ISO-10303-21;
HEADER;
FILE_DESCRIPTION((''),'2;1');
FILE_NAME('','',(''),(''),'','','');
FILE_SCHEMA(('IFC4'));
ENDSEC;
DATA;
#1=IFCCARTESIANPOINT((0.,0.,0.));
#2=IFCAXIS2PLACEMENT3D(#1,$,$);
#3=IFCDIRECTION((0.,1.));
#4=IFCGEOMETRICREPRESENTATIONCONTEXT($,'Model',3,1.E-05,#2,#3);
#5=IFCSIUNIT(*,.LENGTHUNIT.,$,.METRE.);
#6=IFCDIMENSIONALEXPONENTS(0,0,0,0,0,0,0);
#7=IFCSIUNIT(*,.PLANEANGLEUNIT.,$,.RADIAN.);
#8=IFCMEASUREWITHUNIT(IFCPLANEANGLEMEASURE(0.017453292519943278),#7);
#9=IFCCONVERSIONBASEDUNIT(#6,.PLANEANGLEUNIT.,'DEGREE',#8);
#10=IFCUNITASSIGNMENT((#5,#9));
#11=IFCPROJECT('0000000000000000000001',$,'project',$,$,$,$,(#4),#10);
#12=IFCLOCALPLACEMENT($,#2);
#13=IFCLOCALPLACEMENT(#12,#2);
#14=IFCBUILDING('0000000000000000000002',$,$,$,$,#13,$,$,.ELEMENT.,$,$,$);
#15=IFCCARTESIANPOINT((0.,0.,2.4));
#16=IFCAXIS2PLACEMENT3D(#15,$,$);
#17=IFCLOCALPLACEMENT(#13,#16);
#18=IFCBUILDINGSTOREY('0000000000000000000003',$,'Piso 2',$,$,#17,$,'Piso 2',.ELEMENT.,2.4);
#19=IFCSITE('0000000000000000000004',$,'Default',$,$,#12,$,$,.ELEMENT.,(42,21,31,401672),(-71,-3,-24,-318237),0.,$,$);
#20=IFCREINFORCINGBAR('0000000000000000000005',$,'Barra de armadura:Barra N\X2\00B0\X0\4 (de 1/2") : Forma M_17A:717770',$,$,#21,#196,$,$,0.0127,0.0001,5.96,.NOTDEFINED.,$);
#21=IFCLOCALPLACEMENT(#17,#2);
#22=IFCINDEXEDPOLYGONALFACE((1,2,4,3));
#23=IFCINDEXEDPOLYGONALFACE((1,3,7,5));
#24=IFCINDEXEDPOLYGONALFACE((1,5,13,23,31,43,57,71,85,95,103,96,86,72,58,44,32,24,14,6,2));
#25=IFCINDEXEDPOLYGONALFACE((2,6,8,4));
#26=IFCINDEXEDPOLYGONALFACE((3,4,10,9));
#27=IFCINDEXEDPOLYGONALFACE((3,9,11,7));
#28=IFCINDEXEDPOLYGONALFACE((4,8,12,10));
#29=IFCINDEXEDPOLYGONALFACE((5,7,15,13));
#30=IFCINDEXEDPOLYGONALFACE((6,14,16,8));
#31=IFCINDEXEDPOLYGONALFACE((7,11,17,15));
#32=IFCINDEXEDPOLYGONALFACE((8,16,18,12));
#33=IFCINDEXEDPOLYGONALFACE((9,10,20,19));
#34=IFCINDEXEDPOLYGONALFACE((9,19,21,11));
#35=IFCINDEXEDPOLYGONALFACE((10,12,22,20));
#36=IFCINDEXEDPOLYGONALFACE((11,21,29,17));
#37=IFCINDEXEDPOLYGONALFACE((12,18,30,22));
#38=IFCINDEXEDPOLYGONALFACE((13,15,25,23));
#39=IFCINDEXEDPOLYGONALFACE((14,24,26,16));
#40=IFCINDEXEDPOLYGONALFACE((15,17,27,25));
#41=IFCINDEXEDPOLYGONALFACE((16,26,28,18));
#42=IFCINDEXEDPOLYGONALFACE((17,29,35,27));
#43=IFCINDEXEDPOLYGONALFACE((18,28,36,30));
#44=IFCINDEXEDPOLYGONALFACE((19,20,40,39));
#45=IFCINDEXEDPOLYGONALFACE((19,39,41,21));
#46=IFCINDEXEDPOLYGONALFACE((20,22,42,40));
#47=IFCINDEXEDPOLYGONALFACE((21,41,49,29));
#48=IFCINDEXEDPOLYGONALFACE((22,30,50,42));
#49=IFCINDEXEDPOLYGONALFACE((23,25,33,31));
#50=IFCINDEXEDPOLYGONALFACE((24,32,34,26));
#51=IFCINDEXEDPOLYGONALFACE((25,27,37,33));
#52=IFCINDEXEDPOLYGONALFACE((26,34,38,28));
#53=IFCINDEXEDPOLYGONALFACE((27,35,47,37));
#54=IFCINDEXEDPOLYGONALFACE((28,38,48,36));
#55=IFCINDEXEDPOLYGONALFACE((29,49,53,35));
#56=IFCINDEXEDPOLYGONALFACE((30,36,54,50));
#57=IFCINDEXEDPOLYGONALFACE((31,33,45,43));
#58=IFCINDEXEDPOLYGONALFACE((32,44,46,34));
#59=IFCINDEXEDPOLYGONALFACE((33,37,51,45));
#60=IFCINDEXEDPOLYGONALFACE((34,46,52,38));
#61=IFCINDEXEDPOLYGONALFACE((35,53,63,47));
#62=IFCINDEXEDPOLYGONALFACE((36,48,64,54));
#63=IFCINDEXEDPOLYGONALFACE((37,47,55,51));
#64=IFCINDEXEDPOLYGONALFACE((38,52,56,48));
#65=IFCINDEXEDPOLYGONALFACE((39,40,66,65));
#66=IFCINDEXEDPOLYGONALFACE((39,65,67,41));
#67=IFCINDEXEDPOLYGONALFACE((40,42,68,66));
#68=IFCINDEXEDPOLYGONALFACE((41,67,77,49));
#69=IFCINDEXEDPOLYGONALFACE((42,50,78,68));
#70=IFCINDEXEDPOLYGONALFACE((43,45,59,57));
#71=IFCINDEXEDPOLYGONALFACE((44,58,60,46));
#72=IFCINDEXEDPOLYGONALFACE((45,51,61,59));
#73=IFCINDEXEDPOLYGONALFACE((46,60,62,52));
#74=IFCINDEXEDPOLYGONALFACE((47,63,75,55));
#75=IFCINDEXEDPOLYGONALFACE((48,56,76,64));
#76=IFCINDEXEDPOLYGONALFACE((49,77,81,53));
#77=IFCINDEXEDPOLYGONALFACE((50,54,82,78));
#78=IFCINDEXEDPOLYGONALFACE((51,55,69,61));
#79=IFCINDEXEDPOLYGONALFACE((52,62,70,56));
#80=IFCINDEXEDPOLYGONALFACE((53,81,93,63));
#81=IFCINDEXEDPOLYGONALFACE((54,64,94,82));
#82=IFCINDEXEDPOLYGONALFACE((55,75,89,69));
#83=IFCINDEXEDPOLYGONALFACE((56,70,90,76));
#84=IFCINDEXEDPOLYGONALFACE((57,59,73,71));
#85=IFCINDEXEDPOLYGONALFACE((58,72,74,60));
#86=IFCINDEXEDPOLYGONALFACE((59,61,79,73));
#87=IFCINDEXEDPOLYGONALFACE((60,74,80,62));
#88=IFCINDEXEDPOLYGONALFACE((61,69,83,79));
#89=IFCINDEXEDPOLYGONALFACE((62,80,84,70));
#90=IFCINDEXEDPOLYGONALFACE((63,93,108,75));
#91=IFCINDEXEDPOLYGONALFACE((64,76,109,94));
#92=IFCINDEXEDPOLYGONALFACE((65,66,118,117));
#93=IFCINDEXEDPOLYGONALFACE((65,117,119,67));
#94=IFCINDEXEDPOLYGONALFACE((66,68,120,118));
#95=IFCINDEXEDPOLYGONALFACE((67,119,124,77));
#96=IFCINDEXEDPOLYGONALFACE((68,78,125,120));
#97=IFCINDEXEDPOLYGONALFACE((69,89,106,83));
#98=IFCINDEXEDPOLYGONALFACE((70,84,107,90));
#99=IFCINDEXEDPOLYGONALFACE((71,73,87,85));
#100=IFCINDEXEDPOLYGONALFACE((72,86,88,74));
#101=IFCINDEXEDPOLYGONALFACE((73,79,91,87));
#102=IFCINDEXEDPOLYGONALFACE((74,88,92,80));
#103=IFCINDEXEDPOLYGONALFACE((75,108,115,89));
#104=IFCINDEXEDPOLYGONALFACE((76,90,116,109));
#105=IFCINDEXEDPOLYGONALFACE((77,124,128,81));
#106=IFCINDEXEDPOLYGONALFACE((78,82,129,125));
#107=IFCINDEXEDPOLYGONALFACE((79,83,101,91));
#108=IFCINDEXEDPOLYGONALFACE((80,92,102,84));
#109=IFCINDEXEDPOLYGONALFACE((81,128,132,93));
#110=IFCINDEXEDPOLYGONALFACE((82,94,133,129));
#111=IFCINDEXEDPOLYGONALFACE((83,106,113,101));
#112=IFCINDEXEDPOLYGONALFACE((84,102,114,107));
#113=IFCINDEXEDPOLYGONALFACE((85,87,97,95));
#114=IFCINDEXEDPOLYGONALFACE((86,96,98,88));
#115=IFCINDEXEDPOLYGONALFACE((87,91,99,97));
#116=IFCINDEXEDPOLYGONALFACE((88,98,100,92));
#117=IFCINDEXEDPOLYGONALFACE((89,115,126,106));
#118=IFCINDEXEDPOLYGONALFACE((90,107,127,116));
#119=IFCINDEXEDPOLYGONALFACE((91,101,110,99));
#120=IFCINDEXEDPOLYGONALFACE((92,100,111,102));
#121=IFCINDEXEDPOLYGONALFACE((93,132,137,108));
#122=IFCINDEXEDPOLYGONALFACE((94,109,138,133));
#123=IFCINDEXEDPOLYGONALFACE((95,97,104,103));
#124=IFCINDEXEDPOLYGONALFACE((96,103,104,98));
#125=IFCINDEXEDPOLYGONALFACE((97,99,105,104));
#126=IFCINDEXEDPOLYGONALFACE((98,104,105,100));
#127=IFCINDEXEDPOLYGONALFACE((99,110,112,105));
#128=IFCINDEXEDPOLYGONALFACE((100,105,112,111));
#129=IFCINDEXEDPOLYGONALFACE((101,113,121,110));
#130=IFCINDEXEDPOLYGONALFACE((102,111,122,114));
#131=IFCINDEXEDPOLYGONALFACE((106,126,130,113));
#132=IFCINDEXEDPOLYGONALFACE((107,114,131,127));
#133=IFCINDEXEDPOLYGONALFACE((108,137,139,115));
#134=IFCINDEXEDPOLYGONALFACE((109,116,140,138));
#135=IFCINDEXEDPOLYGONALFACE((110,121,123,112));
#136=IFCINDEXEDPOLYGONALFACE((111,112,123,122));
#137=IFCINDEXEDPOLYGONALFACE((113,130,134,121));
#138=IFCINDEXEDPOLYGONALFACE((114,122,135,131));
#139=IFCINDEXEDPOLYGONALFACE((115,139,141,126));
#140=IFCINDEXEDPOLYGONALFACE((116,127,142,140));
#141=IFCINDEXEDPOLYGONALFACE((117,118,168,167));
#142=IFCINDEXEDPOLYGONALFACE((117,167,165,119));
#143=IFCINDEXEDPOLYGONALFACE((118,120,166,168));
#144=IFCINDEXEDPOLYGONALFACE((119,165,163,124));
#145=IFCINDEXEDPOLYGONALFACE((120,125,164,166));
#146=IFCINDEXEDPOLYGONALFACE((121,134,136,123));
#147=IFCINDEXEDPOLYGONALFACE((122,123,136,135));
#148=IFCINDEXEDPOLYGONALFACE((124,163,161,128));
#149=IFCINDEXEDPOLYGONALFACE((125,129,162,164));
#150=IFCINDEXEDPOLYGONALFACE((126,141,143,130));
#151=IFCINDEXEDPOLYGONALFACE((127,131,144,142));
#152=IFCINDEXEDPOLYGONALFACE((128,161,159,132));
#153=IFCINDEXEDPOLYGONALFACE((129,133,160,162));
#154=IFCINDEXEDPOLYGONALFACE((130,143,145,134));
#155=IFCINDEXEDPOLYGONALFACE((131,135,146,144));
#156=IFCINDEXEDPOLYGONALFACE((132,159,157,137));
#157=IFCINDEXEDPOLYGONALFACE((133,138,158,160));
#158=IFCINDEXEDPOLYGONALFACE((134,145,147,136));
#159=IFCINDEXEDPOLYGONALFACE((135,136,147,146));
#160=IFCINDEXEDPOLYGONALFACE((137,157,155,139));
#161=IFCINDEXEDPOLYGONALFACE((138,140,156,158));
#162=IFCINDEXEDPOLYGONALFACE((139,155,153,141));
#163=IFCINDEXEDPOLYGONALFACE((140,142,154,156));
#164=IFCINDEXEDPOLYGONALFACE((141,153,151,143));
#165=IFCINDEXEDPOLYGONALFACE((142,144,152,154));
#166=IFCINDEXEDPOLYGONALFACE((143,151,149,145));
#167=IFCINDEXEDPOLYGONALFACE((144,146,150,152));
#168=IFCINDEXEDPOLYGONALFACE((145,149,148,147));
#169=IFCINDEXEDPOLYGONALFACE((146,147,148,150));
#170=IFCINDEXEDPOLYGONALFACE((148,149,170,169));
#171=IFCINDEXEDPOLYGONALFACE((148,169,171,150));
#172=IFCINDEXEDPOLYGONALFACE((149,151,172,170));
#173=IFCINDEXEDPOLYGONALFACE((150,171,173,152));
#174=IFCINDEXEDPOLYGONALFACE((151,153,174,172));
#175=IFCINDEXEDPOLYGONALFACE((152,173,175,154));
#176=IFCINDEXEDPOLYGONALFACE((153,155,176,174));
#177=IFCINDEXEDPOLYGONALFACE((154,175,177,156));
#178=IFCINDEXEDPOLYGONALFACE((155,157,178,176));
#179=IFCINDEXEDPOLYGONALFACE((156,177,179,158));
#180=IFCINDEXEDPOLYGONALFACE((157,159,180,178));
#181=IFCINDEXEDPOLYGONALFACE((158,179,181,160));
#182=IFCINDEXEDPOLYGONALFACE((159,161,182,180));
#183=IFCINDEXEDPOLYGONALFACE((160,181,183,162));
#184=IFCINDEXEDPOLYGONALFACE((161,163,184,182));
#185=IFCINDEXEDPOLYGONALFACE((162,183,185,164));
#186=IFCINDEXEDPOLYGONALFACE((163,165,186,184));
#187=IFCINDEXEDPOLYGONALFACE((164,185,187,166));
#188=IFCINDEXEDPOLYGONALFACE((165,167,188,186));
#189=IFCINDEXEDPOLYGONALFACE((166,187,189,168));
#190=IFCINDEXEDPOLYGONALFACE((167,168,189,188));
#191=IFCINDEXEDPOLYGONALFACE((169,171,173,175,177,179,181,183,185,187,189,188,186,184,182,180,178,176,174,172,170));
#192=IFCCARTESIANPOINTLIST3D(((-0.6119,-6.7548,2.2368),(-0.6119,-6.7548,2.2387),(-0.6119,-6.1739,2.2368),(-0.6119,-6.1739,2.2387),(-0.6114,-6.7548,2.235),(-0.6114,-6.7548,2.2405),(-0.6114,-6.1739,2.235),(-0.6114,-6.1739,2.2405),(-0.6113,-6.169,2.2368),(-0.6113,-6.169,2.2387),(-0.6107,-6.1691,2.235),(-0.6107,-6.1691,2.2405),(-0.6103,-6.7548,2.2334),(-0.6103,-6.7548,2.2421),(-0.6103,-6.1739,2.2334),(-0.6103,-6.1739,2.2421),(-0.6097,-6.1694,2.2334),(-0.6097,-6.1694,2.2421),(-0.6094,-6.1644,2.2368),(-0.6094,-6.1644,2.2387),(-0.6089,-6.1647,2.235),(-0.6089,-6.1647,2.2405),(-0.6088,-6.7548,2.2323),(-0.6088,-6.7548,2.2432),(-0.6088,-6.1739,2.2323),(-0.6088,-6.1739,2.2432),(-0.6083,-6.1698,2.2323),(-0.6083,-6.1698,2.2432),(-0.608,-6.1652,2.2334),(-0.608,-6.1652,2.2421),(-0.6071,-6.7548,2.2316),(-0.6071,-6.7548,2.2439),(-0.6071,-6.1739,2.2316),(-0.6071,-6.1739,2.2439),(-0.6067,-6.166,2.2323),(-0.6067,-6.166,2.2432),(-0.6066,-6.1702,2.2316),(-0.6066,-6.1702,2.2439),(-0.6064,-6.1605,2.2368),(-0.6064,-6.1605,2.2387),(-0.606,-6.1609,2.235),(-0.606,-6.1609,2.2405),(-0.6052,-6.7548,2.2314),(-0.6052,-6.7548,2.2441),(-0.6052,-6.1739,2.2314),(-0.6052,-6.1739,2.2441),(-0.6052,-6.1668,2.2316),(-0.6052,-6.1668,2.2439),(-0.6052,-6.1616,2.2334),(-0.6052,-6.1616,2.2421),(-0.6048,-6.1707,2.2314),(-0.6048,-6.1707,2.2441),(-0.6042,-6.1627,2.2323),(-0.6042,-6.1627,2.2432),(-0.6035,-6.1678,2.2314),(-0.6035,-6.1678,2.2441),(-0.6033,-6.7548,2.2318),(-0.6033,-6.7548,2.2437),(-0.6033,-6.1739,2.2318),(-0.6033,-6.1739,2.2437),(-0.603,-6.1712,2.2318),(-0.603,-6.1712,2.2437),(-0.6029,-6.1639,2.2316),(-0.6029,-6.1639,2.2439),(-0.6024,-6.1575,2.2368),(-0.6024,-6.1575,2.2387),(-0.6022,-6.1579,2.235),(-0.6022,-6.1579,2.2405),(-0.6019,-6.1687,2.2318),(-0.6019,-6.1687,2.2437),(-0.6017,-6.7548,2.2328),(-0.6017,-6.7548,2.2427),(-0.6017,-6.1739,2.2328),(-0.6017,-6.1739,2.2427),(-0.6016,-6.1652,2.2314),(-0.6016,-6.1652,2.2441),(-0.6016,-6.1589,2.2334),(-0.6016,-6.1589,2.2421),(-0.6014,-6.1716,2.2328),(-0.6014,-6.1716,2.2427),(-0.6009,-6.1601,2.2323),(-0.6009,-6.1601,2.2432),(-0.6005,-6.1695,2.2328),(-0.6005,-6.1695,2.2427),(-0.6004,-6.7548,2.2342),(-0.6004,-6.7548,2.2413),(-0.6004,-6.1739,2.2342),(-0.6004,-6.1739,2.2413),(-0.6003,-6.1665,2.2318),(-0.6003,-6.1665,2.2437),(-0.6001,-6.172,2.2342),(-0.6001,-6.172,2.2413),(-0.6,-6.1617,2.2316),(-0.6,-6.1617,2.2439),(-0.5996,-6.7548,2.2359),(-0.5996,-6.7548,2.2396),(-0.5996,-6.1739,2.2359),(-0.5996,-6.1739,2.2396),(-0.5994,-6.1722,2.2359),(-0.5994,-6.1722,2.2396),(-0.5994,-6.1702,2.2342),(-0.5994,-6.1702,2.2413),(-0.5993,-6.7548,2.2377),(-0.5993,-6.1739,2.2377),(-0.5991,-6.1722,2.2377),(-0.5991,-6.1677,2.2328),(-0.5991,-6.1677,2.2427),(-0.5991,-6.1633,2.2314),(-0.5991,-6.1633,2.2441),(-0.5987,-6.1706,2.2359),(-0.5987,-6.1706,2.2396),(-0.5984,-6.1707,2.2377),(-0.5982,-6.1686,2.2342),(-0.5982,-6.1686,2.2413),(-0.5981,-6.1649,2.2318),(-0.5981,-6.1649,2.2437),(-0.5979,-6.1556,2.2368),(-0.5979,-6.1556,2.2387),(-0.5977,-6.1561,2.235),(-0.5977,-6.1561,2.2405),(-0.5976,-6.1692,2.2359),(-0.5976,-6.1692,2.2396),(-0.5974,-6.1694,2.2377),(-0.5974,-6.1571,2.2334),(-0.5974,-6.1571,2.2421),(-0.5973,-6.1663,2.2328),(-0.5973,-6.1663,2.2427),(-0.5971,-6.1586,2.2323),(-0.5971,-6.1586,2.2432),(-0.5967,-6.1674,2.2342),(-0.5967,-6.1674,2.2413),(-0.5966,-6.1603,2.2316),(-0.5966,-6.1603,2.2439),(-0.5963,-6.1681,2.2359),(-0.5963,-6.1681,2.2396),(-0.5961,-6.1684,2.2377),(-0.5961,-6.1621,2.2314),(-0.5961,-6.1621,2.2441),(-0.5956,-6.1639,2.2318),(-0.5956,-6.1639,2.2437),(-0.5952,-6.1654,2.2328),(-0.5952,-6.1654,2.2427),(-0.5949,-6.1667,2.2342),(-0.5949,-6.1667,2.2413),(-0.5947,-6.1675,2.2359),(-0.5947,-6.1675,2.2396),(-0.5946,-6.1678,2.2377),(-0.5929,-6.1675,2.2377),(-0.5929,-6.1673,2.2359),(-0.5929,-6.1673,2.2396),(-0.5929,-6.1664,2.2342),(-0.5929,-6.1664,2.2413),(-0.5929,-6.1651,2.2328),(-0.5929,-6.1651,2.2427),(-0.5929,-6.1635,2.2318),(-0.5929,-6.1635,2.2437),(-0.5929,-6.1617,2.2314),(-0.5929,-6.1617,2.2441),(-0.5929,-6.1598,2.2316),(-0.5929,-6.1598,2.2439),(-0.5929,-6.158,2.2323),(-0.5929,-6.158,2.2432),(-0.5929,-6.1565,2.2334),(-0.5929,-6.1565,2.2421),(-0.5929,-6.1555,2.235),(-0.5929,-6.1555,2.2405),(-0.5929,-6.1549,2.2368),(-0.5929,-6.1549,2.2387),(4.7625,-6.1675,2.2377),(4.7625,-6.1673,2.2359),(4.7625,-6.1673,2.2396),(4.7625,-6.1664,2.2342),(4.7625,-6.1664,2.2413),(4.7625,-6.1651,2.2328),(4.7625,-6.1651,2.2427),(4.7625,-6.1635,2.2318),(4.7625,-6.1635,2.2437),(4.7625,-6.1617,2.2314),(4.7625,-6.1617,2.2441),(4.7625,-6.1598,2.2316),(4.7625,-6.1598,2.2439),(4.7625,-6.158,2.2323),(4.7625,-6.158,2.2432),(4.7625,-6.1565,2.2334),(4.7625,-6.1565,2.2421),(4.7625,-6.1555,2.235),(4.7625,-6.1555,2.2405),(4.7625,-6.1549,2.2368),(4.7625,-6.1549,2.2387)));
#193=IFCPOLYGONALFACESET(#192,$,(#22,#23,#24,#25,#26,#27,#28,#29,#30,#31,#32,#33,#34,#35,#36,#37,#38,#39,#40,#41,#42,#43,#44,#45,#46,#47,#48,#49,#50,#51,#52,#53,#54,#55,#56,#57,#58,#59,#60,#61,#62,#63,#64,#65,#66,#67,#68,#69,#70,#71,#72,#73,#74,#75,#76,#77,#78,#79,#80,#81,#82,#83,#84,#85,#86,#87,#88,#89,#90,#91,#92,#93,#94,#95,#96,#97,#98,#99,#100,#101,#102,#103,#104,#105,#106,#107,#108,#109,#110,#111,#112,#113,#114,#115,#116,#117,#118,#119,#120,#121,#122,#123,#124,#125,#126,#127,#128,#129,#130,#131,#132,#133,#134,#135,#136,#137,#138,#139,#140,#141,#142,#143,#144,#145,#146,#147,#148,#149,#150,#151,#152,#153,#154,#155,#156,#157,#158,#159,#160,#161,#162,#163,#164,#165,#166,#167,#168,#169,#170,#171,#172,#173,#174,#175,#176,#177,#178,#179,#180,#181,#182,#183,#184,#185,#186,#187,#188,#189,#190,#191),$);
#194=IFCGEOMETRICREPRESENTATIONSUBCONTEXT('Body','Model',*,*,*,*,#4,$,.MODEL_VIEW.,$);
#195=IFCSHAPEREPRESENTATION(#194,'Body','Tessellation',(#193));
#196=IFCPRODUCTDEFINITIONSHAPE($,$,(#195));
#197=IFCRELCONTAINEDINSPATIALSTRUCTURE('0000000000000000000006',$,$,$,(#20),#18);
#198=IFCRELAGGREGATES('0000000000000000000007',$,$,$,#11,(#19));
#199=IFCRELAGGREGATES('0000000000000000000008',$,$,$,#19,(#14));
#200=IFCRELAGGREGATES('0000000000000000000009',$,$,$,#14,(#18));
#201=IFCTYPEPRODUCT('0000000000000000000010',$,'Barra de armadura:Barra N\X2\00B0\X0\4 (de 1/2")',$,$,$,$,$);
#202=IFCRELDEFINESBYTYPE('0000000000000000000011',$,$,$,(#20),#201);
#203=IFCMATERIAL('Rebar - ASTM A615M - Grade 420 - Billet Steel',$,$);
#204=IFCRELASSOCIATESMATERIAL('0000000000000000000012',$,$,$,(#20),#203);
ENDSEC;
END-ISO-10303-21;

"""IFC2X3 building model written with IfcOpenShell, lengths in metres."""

from ifc_helpers import new_model, entity, si_unit, converted_unit, direction, frame, origin, place, context, subcontext, project, spatial, material, type_object, element, save


model = new_model("IFC2X3")

# Units and contexts
model_context = context("Model", 3, precision=1e-05, world=origin(), true_north=direction((0.0, 1.0)))
body_context = subcontext(model_context, "Body", "Model", "MODEL_VIEW")
ifc_project = project(units=[si_unit("LENGTHUNIT", "METRE"), converted_unit("PLANEANGLEUNIT", "DEGREE", entity("IfcPlaneAngleMeasure", 0.017453292519943278), si_unit("PLANEANGLEUNIT", "RADIAN"), dimensions=[0, 0, 0, 0, 0, 0, 0])], contexts=[model_context])

# Site, building, storey
site_placement = place(None, origin())
site = spatial("IfcSite", under=ifc_project, at=site_placement, Name="Default", CompositionType="ELEMENT", RefLatitude=(42, 21, 31, 401672), RefLongitude=(-71, -3, -24, -318237), RefElevation=0.0)
building_placement = place(site_placement, origin())
building = spatial("IfcBuilding", under=site, at=building_placement, CompositionType="ELEMENT")
storey_placement = place(building_placement, frame((0.0, 0.0, 2.4)))
storey = spatial("IfcBuildingStorey", under=building, at=storey_placement, Name="Piso 2", LongName="Piso 2", CompositionType="ELEMENT", Elevation=2.4)

# Reinforcing bar
ifc_material_1 = material(Name="Rebar - ASTM A615M - Grade 420 - Billet Steel")
type_product_1 = type_object("IfcTypeProduct", Name="Barra de armadura:Barra N°4 (de 1/2\")")
reinforcing_bar_1_placement = place(storey_placement, origin())
element("IfcReinforcingBar", 1, at=reinforcing_bar_1_placement, inside=storey, type_object=type_product_1, material=ifc_material_1, Name="Barra de armadura:Barra N°4 (de 1/2\") : Forma M_17A:717770", BarLength=5.96, BarRole="NOTDEFINED", CrossSectionArea=0.0001, NominalDiameter=0.0127, context=body_context, shape_type="AdvancedSweptSolid", body=[
    entity("IfcSweptDiskSolid", entity("IfcCompositeCurve", [entity("IfcCompositeCurveSegment", "CONTINUOUS", True, entity("IfcPolyline", [entity("IfcCartesianPoint", [4.7625, -6.1612, 2.2377]), entity("IfcCartesianPoint", [-0.5929, -6.1612, 2.2377])])), entity("IfcCompositeCurveSegment", "CONTINUOUS", True, entity("IfcTrimmedCurve", entity("IfcCircle", entity("IfcAxis2Placement3D", entity("IfcCartesianPoint", [-0.5929, -6.1739, 2.2377]), entity("IfcDirection", [0.0, 0.0, 1.0]), entity("IfcDirection", [-1.0, 0.0, 0.0])), 0.0127), [entity("IfcParameterValue", 270.0)], [entity("IfcParameterValue", 360.0)], True, "PARAMETER")), entity("IfcCompositeCurveSegment", "CONTINUOUS", True, entity("IfcPolyline", [entity("IfcCartesianPoint", [-0.6056, -6.1739, 2.2377]), entity("IfcCartesianPoint", [-0.6056, -6.7548, 2.2377])]))], False), 0.0063, None, 0.0, 92.0),
])

save(model, "model.ifc")
